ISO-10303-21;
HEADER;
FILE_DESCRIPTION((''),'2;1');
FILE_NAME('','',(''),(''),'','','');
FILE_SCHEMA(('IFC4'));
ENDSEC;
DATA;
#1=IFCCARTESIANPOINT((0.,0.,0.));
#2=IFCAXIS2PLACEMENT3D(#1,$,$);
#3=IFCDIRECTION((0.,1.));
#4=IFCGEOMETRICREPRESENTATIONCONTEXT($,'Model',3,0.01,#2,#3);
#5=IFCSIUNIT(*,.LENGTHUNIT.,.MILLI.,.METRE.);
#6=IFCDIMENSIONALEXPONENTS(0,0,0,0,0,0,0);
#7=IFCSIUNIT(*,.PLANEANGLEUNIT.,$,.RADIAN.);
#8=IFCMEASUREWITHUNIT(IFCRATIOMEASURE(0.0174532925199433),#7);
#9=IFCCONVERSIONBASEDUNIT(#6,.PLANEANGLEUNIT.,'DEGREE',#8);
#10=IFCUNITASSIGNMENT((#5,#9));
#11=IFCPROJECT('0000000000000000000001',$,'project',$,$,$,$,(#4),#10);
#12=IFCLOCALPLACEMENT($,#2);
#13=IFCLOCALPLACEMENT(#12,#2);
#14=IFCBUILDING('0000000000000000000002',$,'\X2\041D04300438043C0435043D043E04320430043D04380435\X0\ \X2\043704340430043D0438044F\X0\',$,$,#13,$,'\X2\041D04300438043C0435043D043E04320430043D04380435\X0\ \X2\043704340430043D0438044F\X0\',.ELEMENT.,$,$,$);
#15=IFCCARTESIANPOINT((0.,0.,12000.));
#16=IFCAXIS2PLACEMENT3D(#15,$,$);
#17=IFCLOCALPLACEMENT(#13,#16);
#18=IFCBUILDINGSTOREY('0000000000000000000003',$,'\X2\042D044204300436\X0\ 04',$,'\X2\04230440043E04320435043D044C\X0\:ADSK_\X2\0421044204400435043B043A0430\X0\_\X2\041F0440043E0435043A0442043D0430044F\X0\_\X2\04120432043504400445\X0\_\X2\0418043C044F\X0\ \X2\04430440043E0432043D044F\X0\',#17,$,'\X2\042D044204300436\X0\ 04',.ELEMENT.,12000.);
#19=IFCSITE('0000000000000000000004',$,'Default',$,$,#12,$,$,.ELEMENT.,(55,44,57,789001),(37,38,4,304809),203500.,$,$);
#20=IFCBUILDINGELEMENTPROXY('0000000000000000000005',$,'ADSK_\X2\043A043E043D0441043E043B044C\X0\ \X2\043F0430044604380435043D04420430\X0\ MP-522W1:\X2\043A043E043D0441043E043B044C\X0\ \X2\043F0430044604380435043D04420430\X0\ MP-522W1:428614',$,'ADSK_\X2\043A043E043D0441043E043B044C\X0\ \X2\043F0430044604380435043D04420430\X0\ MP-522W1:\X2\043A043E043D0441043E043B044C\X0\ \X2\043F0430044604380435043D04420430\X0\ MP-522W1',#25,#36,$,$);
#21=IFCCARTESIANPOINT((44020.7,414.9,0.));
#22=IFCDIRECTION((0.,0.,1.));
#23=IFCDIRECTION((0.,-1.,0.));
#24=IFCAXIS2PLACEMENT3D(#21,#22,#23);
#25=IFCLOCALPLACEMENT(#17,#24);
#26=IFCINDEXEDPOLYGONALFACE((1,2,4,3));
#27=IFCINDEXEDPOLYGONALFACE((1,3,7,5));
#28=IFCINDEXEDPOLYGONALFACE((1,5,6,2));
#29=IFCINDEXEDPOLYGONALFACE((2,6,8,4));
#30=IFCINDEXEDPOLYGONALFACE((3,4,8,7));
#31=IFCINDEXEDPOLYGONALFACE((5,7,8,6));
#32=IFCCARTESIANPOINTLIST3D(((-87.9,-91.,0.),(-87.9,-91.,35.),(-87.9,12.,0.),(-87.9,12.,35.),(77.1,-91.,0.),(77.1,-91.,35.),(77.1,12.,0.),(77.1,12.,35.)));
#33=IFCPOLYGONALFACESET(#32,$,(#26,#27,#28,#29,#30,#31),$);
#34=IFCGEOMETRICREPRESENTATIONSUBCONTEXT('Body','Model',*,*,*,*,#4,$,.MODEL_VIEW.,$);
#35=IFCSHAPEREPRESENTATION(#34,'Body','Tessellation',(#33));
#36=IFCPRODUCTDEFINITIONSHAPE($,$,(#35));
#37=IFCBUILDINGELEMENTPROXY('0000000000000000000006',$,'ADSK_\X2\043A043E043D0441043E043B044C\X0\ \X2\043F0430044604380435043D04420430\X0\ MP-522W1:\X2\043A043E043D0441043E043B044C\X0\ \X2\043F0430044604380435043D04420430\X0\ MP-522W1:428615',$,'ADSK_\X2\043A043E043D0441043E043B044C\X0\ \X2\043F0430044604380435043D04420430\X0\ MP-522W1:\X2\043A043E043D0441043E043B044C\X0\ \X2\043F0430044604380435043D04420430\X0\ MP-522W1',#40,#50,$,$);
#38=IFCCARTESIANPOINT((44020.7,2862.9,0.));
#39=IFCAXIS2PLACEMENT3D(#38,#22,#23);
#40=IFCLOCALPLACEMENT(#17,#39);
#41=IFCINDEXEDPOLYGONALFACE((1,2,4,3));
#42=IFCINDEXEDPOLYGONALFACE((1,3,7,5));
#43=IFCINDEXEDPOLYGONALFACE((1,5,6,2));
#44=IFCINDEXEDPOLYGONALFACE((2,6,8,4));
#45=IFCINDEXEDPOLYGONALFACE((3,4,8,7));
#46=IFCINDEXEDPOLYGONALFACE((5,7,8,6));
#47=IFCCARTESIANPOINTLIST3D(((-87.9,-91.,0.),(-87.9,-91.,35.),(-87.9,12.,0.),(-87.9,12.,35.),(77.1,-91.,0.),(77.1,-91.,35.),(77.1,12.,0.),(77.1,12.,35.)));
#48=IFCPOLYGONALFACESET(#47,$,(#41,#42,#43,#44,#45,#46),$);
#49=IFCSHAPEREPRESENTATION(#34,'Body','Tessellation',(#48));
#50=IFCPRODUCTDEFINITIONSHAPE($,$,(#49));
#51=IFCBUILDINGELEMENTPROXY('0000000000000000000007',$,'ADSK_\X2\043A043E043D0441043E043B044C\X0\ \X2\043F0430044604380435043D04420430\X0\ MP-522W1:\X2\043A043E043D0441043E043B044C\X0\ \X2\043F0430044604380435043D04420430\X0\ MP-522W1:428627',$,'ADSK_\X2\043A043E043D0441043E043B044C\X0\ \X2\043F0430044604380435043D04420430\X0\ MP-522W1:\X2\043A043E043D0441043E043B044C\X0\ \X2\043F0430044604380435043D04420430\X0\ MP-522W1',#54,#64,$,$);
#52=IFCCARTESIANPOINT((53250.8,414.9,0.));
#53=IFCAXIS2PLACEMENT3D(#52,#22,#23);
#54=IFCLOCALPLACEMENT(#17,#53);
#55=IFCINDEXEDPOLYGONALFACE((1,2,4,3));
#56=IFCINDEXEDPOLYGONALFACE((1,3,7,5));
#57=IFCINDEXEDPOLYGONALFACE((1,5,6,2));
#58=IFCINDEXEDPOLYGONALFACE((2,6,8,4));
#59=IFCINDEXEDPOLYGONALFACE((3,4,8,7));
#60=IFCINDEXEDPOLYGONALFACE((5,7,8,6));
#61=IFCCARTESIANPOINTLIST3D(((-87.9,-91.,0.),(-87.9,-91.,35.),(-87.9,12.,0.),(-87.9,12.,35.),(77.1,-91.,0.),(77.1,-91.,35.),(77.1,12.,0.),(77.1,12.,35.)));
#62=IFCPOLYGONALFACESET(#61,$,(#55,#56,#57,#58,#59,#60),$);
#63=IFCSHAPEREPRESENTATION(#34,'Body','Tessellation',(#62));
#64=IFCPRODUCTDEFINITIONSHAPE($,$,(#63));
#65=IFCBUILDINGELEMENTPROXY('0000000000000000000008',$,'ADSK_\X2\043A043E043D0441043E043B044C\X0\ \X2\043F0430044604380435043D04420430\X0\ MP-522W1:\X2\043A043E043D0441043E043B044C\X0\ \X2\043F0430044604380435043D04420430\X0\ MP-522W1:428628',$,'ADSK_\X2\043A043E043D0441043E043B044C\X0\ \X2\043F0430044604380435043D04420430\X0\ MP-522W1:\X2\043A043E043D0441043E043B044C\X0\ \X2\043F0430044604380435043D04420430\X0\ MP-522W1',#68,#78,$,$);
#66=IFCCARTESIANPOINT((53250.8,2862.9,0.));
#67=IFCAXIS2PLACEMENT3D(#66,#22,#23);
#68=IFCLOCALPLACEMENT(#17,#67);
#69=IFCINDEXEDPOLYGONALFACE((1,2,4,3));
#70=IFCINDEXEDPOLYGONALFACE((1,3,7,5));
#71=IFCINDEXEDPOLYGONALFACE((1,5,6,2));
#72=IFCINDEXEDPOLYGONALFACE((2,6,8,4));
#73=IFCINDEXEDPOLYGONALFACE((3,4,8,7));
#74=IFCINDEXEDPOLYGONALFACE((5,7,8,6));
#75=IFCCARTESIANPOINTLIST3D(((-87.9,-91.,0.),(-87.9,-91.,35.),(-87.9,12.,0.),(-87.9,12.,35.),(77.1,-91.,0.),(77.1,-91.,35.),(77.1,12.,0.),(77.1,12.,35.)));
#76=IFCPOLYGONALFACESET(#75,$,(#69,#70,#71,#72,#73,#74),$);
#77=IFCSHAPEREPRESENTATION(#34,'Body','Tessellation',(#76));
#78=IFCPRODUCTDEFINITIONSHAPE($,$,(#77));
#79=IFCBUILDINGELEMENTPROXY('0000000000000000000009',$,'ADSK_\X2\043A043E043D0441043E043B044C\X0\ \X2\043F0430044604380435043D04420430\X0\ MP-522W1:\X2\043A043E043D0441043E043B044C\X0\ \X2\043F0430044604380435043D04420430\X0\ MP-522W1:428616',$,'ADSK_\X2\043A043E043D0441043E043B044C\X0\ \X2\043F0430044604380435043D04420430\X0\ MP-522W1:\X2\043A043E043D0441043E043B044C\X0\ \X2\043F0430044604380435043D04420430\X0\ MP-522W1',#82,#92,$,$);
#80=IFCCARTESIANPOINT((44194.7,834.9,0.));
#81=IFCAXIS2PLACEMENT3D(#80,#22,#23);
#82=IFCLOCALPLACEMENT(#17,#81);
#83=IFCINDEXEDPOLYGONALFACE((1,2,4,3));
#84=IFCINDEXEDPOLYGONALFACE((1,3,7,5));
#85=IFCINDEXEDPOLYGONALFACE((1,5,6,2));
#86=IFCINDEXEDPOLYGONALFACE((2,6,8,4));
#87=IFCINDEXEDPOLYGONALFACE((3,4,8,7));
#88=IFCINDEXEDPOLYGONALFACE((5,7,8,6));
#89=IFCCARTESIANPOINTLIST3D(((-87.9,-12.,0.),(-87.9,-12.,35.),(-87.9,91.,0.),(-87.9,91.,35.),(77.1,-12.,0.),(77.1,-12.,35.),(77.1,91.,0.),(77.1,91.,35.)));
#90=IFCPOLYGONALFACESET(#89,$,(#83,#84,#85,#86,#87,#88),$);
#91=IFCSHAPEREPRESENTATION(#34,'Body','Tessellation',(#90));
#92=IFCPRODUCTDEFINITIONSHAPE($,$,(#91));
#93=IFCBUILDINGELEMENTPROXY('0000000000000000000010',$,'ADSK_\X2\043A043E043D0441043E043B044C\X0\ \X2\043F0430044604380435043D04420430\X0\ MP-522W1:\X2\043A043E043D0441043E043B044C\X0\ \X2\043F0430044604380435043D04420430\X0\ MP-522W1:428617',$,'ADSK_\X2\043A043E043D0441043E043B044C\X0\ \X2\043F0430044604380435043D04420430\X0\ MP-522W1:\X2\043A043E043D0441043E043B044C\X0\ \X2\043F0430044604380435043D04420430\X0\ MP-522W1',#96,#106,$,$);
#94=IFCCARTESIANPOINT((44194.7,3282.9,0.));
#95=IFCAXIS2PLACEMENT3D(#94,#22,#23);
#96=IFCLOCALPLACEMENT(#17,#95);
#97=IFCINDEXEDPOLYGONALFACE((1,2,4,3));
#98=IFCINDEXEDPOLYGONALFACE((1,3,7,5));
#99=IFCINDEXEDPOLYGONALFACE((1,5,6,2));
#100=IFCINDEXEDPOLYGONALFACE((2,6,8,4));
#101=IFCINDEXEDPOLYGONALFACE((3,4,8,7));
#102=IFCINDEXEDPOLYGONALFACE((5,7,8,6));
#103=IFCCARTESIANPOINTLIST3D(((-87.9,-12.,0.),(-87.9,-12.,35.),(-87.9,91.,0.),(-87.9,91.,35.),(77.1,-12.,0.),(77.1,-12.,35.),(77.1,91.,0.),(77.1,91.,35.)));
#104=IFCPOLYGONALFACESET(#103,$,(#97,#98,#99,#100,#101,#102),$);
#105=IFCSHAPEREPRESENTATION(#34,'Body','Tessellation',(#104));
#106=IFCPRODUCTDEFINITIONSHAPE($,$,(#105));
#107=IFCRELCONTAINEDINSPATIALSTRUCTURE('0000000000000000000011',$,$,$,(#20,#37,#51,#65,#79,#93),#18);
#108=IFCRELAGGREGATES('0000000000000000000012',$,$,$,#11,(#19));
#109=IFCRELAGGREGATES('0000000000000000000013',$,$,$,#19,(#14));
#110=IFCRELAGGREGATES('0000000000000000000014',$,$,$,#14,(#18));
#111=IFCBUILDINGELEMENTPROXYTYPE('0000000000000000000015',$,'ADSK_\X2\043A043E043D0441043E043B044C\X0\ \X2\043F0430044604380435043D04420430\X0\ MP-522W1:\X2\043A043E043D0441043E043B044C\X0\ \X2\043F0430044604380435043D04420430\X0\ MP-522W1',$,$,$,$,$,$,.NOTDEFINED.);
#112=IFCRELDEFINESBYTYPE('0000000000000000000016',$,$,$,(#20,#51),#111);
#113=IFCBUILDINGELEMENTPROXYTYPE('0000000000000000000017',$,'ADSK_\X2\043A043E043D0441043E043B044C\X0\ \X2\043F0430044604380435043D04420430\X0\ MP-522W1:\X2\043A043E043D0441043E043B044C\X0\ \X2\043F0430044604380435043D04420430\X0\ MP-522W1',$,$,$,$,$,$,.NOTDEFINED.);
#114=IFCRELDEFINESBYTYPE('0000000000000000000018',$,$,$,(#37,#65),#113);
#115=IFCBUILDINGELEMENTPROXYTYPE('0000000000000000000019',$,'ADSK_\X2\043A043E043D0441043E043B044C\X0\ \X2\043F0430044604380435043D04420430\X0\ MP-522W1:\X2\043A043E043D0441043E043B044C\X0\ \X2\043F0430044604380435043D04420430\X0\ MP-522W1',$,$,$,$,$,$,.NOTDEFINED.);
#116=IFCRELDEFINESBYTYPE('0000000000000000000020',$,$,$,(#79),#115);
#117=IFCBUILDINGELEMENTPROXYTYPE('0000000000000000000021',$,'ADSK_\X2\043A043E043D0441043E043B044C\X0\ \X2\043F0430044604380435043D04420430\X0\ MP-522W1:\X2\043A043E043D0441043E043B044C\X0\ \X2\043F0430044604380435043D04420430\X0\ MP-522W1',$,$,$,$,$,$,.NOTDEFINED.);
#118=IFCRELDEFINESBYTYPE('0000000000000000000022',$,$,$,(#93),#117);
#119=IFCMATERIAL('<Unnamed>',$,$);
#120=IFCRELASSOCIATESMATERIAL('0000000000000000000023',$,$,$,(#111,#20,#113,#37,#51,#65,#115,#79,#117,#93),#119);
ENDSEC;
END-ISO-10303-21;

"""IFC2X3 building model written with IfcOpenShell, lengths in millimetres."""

from ifc_helpers import new_model, entity, si_unit, converted_unit, direction, frame, origin, origin_2d_with_axis, place, context, subcontext, project, spatial, rectangle, extrude, source, transform, mapped, material, type_object, type_shapes, element, save


model = new_model("IFC2X3")

# Units and contexts
model_context = context("Model", 3, precision=0.01, world=origin(), true_north=direction((0.0, 1.0)))
body_context = subcontext(model_context, "Body", "Model", "MODEL_VIEW")
ifc_project = project(units=[si_unit("LENGTHUNIT", "METRE", prefix="MILLI"), converted_unit("PLANEANGLEUNIT", "DEGREE", entity("IfcRatioMeasure", 0.0174532925199433), si_unit("PLANEANGLEUNIT", "RADIAN"), dimensions=[0, 0, 0, 0, 0, 0, 0])], contexts=[model_context])

# Site, building, storey
site_placement = place(None, origin())
site = spatial("IfcSite", under=ifc_project, at=site_placement, Name="Default", CompositionType="ELEMENT", RefLatitude=(55, 44, 57, 789001), RefLongitude=(37, 38, 4, 304809), RefElevation=203500.0)
building_placement = place(site_placement, origin())
building = spatial("IfcBuilding", under=site, at=building_placement, Name="Наименование здания", LongName="Наименование здания", CompositionType="ELEMENT")
storey_placement = place(building_placement, frame((0.0, 0.0, 12000.0)))
storey = spatial("IfcBuildingStorey", under=building, at=storey_placement, Name="Этаж 04", ObjectType="Уровень:ADSK_Стрелка_Проектная_Вверх_Имя уровня", LongName="Этаж 04", CompositionType="ELEMENT", Elevation=12000.0)

# Building element proxies
ifc_material = material(Name="<Unnamed>")
building_element_proxy_type_1 = type_object("IfcBuildingElementProxyType", Name="ADSK_консоль пациента MP-522W1:консоль пациента MP-522W1", PredefinedType="NOTDEFINED", material=ifc_material)
shared_shape_1 = source(origin(), body_context, "Body", "SweptSolid", [
    extrude(rectangle(XDim=165.0, YDim=103.0, at=origin_2d_with_axis()), frame((-5.4, -39.5, 0.0), z_axis=(0.0, 0.0, 1.0), x_axis=(-1.0, 0.0, 0.0)), (0.0, 0.0, 1.0), 35.0),
])
type_shapes(building_element_proxy_type_1, [shared_shape_1])
proxy_1_placement = place(storey_placement, frame((44020.7, 414.9, 0.0), z_axis=(0.0, 0.0, 1.0), x_axis=(0.0, -1.0, 0.0)))
element("IfcBuildingElementProxy", 1, at=proxy_1_placement, inside=storey, type_object=building_element_proxy_type_1, material=ifc_material, Name="ADSK_консоль пациента MP-522W1:консоль пациента MP-522W1:428614", ObjectType="ADSK_консоль пациента MP-522W1:консоль пациента MP-522W1", context=body_context, shape_type="MappedRepresentation", body=[
    mapped(shared_shape_1, transform((0.0, 0.0, 0.0), scale=1.0)),
])
building_element_proxy_type_2 = type_object("IfcBuildingElementProxyType", Name="ADSK_консоль пациента MP-522W1:консоль пациента MP-522W1", PredefinedType="NOTDEFINED", material=ifc_material)
type_shapes(building_element_proxy_type_2, [shared_shape_1])
proxy_2_placement = place(storey_placement, frame((44020.7, 2862.9, 0.0), z_axis=(0.0, 0.0, 1.0), x_axis=(0.0, -1.0, 0.0)))
element("IfcBuildingElementProxy", 2, at=proxy_2_placement, inside=storey, type_object=building_element_proxy_type_2, material=ifc_material, Name="ADSK_консоль пациента MP-522W1:консоль пациента MP-522W1:428615", ObjectType="ADSK_консоль пациента MP-522W1:консоль пациента MP-522W1", context=body_context, shape_type="MappedRepresentation", body=[
    mapped(shared_shape_1, transform((0.0, 0.0, 0.0), scale=1.0)),
])
proxy_3_placement = place(storey_placement, frame((53250.8, 414.9, 0.0), z_axis=(0.0, 0.0, 1.0), x_axis=(0.0, -1.0, 0.0)))
element("IfcBuildingElementProxy", 3, at=proxy_3_placement, inside=storey, type_object=building_element_proxy_type_1, material=ifc_material, Name="ADSK_консоль пациента MP-522W1:консоль пациента MP-522W1:428627", ObjectType="ADSK_консоль пациента MP-522W1:консоль пациента MP-522W1", context=body_context, shape_type="MappedRepresentation", body=[
    mapped(shared_shape_1, transform((0.0, 0.0, 0.0), scale=1.0)),
])
proxy_4_placement = place(storey_placement, frame((53250.8, 2862.9, 0.0), z_axis=(0.0, 0.0, 1.0), x_axis=(0.0, -1.0, 0.0)))
element("IfcBuildingElementProxy", 4, at=proxy_4_placement, inside=storey, type_object=building_element_proxy_type_2, material=ifc_material, Name="ADSK_консоль пациента MP-522W1:консоль пациента MP-522W1:428628", ObjectType="ADSK_консоль пациента MP-522W1:консоль пациента MP-522W1", context=body_context, shape_type="MappedRepresentation", body=[
    mapped(shared_shape_1, transform((0.0, 0.0, 0.0), scale=1.0)),
])
building_element_proxy_type_3 = type_object("IfcBuildingElementProxyType", Name="ADSK_консоль пациента MP-522W1:консоль пациента MP-522W1", PredefinedType="NOTDEFINED", material=ifc_material)
shared_shape_2 = source(origin(), body_context, "Body", "SweptSolid", [
    extrude(rectangle(XDim=103.0, YDim=165.0, at=origin_2d_with_axis()), frame((-5.4, 39.5, 0.0), z_axis=(0.0, 0.0, 1.0), x_axis=(0.0, 1.0, 0.0)), (0.0, 0.0, 1.0), 35.0),
])
type_shapes(building_element_proxy_type_3, [shared_shape_2])
proxy_5_placement = place(storey_placement, frame((44194.7, 834.9, 0.0), z_axis=(0.0, 0.0, 1.0), x_axis=(0.0, -1.0, 0.0)))
element("IfcBuildingElementProxy", 5, at=proxy_5_placement, inside=storey, type_object=building_element_proxy_type_3, material=ifc_material, Name="ADSK_консоль пациента MP-522W1:консоль пациента MP-522W1:428616", ObjectType="ADSK_консоль пациента MP-522W1:консоль пациента MP-522W1", context=body_context, shape_type="MappedRepresentation", body=[
    mapped(shared_shape_2, transform((0.0, 0.0, 0.0), scale=1.0)),
])
building_element_proxy_type_4 = type_object("IfcBuildingElementProxyType", Name="ADSK_консоль пациента MP-522W1:консоль пациента MP-522W1", PredefinedType="NOTDEFINED", material=ifc_material)
type_shapes(building_element_proxy_type_4, [shared_shape_2])
proxy_6_placement = place(storey_placement, frame((44194.7, 3282.9, 0.0), z_axis=(0.0, 0.0, 1.0), x_axis=(0.0, -1.0, 0.0)))
element("IfcBuildingElementProxy", 6, at=proxy_6_placement, inside=storey, type_object=building_element_proxy_type_4, material=ifc_material, Name="ADSK_консоль пациента MP-522W1:консоль пациента MP-522W1:428617", ObjectType="ADSK_консоль пациента MP-522W1:консоль пациента MP-522W1", context=body_context, shape_type="MappedRepresentation", body=[
    mapped(shared_shape_2, transform((0.0, 0.0, 0.0), scale=1.0)),
])

save(model, "model.ifc")
